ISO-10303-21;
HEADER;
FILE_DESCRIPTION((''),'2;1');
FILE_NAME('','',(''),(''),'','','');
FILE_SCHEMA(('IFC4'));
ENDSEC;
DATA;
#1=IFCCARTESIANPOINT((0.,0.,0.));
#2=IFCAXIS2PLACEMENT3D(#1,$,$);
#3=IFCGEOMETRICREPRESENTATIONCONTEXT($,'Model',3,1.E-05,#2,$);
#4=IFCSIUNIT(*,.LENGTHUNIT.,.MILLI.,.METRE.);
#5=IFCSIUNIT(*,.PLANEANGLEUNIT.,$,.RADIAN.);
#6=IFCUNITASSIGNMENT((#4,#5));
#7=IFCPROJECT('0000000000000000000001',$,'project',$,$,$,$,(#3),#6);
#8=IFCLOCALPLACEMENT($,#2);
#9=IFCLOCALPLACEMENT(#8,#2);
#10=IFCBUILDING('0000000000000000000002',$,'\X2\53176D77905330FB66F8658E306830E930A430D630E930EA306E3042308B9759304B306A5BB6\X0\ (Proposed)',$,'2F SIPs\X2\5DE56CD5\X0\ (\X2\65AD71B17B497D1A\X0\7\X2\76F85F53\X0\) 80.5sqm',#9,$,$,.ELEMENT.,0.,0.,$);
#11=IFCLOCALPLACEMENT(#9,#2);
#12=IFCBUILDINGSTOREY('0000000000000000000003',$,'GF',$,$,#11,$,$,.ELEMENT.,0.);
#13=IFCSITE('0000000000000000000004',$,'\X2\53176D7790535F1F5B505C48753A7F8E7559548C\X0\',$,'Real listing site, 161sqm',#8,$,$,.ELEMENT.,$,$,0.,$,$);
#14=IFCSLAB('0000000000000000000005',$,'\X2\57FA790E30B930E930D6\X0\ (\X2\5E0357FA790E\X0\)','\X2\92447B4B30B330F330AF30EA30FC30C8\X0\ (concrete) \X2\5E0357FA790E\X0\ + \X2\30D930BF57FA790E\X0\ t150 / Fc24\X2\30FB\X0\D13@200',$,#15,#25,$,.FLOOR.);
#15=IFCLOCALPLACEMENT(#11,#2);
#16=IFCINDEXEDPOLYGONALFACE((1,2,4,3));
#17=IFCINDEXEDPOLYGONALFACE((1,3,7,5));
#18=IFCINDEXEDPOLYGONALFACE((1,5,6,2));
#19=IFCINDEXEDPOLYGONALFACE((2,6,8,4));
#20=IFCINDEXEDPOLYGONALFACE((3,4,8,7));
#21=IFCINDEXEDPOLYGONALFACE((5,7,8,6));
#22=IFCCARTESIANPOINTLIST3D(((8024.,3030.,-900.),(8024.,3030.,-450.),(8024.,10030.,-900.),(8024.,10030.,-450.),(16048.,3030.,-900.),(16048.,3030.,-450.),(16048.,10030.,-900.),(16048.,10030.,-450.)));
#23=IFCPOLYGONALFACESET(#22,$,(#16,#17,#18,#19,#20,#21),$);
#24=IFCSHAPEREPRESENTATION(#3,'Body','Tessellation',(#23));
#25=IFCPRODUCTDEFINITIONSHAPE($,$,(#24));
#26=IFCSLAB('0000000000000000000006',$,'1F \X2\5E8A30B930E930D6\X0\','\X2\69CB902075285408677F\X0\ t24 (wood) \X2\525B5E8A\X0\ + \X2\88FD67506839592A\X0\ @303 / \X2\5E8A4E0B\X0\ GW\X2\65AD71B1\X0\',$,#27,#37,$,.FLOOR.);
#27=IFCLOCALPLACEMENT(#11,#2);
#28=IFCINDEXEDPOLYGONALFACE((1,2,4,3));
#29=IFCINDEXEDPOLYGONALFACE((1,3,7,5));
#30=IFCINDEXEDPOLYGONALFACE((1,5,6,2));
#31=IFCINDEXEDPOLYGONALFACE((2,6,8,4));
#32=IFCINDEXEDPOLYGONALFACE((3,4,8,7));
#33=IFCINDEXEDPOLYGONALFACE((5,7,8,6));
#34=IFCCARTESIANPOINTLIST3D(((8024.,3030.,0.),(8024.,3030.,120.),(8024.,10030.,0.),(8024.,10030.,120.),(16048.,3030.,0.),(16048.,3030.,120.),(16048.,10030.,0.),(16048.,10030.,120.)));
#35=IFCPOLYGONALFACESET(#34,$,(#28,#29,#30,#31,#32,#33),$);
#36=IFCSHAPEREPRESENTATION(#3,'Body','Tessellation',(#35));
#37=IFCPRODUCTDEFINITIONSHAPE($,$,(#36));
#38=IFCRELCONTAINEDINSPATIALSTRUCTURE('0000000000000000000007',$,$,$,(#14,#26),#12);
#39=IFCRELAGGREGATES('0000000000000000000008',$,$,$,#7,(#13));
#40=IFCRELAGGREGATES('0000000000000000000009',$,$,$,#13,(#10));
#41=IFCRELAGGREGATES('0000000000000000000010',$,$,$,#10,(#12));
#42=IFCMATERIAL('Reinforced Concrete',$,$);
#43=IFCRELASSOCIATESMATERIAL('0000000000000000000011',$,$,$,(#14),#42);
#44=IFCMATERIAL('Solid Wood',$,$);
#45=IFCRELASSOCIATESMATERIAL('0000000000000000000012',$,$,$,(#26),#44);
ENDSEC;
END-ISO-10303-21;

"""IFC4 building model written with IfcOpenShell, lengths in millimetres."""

from ifc_helpers import new_model, si_unit, frame, frame_2d, origin, place, context, project, spatial, rectangle, extrude, material, element, save


model = new_model("IFC4")

# Units and contexts
model_context = context("Model", 3, precision=1e-05, world=origin())
ifc_project = project(units=[si_unit("LENGTHUNIT", "METRE", prefix="MILLI"), si_unit("PLANEANGLEUNIT", "RADIAN")], contexts=[model_context])

# Site, building, storey
site_placement = place(None, origin())
site = spatial("IfcSite", under=ifc_project, at=site_placement, Name="北海道弟子屈町美留和", ObjectType="Real listing site, 161sqm", CompositionType="ELEMENT", RefElevation=0.0)
building_placement = place(site_placement, origin())
building = spatial("IfcBuilding", under=site, at=building_placement, Name="北海道・書斎とライブラリのある静かな家 (Proposed)", ObjectType="2F SIPs工法 (断熱等級7相当) 80.5sqm", CompositionType="ELEMENT", ElevationOfRefHeight=0.0, ElevationOfTerrain=0.0)
storey_placement = place(building_placement, origin())
storey = spatial("IfcBuildingStorey", under=building, at=storey_placement, Name="GF", CompositionType="ELEMENT", Elevation=0.0)

# Slabs
ifc_material_1 = material(Name="Reinforced Concrete")
slab_1_placement = place(storey_placement, frame((4012.0, 1515.0, -450.0)))
element("IfcSlab", 1, at=slab_1_placement, inside=storey, material=ifc_material_1, Name="基礎スラブ (布基礎)", Description="鉄筋コンクリート (concrete) 布基礎 + ベタ基礎 t150 / Fc24・D13@200", PredefinedType="FLOOR", context=model_context, shape_type="SweptSolid", body=[
    extrude(rectangle(XDim=8024.0, YDim=7000.0, at=frame_2d((4012.0, 3500.0))), frame((4012.0, 1515.0, -450.0)), (0.0, 0.0, 1.0), 450.0),
])
ifc_material_2 = material(Name="Solid Wood")
slab_2_placement = place(storey_placement, frame((4012.0, 1515.0, 0.0)))
element("IfcSlab", 2, at=slab_2_placement, inside=storey, material=ifc_material_2, Name="1F 床スラブ", Description="構造用合板 t24 (wood) 剛床 + 製材根太 @303 / 床下 GW断熱", PredefinedType="FLOOR", context=model_context, shape_type="SweptSolid", body=[
    extrude(rectangle(XDim=8024.0, YDim=7000.0, at=frame_2d((4012.0, 3500.0))), frame((4012.0, 1515.0, 0.0)), (0.0, 0.0, 1.0), 120.0),
])

save(model, "model.ifc")
